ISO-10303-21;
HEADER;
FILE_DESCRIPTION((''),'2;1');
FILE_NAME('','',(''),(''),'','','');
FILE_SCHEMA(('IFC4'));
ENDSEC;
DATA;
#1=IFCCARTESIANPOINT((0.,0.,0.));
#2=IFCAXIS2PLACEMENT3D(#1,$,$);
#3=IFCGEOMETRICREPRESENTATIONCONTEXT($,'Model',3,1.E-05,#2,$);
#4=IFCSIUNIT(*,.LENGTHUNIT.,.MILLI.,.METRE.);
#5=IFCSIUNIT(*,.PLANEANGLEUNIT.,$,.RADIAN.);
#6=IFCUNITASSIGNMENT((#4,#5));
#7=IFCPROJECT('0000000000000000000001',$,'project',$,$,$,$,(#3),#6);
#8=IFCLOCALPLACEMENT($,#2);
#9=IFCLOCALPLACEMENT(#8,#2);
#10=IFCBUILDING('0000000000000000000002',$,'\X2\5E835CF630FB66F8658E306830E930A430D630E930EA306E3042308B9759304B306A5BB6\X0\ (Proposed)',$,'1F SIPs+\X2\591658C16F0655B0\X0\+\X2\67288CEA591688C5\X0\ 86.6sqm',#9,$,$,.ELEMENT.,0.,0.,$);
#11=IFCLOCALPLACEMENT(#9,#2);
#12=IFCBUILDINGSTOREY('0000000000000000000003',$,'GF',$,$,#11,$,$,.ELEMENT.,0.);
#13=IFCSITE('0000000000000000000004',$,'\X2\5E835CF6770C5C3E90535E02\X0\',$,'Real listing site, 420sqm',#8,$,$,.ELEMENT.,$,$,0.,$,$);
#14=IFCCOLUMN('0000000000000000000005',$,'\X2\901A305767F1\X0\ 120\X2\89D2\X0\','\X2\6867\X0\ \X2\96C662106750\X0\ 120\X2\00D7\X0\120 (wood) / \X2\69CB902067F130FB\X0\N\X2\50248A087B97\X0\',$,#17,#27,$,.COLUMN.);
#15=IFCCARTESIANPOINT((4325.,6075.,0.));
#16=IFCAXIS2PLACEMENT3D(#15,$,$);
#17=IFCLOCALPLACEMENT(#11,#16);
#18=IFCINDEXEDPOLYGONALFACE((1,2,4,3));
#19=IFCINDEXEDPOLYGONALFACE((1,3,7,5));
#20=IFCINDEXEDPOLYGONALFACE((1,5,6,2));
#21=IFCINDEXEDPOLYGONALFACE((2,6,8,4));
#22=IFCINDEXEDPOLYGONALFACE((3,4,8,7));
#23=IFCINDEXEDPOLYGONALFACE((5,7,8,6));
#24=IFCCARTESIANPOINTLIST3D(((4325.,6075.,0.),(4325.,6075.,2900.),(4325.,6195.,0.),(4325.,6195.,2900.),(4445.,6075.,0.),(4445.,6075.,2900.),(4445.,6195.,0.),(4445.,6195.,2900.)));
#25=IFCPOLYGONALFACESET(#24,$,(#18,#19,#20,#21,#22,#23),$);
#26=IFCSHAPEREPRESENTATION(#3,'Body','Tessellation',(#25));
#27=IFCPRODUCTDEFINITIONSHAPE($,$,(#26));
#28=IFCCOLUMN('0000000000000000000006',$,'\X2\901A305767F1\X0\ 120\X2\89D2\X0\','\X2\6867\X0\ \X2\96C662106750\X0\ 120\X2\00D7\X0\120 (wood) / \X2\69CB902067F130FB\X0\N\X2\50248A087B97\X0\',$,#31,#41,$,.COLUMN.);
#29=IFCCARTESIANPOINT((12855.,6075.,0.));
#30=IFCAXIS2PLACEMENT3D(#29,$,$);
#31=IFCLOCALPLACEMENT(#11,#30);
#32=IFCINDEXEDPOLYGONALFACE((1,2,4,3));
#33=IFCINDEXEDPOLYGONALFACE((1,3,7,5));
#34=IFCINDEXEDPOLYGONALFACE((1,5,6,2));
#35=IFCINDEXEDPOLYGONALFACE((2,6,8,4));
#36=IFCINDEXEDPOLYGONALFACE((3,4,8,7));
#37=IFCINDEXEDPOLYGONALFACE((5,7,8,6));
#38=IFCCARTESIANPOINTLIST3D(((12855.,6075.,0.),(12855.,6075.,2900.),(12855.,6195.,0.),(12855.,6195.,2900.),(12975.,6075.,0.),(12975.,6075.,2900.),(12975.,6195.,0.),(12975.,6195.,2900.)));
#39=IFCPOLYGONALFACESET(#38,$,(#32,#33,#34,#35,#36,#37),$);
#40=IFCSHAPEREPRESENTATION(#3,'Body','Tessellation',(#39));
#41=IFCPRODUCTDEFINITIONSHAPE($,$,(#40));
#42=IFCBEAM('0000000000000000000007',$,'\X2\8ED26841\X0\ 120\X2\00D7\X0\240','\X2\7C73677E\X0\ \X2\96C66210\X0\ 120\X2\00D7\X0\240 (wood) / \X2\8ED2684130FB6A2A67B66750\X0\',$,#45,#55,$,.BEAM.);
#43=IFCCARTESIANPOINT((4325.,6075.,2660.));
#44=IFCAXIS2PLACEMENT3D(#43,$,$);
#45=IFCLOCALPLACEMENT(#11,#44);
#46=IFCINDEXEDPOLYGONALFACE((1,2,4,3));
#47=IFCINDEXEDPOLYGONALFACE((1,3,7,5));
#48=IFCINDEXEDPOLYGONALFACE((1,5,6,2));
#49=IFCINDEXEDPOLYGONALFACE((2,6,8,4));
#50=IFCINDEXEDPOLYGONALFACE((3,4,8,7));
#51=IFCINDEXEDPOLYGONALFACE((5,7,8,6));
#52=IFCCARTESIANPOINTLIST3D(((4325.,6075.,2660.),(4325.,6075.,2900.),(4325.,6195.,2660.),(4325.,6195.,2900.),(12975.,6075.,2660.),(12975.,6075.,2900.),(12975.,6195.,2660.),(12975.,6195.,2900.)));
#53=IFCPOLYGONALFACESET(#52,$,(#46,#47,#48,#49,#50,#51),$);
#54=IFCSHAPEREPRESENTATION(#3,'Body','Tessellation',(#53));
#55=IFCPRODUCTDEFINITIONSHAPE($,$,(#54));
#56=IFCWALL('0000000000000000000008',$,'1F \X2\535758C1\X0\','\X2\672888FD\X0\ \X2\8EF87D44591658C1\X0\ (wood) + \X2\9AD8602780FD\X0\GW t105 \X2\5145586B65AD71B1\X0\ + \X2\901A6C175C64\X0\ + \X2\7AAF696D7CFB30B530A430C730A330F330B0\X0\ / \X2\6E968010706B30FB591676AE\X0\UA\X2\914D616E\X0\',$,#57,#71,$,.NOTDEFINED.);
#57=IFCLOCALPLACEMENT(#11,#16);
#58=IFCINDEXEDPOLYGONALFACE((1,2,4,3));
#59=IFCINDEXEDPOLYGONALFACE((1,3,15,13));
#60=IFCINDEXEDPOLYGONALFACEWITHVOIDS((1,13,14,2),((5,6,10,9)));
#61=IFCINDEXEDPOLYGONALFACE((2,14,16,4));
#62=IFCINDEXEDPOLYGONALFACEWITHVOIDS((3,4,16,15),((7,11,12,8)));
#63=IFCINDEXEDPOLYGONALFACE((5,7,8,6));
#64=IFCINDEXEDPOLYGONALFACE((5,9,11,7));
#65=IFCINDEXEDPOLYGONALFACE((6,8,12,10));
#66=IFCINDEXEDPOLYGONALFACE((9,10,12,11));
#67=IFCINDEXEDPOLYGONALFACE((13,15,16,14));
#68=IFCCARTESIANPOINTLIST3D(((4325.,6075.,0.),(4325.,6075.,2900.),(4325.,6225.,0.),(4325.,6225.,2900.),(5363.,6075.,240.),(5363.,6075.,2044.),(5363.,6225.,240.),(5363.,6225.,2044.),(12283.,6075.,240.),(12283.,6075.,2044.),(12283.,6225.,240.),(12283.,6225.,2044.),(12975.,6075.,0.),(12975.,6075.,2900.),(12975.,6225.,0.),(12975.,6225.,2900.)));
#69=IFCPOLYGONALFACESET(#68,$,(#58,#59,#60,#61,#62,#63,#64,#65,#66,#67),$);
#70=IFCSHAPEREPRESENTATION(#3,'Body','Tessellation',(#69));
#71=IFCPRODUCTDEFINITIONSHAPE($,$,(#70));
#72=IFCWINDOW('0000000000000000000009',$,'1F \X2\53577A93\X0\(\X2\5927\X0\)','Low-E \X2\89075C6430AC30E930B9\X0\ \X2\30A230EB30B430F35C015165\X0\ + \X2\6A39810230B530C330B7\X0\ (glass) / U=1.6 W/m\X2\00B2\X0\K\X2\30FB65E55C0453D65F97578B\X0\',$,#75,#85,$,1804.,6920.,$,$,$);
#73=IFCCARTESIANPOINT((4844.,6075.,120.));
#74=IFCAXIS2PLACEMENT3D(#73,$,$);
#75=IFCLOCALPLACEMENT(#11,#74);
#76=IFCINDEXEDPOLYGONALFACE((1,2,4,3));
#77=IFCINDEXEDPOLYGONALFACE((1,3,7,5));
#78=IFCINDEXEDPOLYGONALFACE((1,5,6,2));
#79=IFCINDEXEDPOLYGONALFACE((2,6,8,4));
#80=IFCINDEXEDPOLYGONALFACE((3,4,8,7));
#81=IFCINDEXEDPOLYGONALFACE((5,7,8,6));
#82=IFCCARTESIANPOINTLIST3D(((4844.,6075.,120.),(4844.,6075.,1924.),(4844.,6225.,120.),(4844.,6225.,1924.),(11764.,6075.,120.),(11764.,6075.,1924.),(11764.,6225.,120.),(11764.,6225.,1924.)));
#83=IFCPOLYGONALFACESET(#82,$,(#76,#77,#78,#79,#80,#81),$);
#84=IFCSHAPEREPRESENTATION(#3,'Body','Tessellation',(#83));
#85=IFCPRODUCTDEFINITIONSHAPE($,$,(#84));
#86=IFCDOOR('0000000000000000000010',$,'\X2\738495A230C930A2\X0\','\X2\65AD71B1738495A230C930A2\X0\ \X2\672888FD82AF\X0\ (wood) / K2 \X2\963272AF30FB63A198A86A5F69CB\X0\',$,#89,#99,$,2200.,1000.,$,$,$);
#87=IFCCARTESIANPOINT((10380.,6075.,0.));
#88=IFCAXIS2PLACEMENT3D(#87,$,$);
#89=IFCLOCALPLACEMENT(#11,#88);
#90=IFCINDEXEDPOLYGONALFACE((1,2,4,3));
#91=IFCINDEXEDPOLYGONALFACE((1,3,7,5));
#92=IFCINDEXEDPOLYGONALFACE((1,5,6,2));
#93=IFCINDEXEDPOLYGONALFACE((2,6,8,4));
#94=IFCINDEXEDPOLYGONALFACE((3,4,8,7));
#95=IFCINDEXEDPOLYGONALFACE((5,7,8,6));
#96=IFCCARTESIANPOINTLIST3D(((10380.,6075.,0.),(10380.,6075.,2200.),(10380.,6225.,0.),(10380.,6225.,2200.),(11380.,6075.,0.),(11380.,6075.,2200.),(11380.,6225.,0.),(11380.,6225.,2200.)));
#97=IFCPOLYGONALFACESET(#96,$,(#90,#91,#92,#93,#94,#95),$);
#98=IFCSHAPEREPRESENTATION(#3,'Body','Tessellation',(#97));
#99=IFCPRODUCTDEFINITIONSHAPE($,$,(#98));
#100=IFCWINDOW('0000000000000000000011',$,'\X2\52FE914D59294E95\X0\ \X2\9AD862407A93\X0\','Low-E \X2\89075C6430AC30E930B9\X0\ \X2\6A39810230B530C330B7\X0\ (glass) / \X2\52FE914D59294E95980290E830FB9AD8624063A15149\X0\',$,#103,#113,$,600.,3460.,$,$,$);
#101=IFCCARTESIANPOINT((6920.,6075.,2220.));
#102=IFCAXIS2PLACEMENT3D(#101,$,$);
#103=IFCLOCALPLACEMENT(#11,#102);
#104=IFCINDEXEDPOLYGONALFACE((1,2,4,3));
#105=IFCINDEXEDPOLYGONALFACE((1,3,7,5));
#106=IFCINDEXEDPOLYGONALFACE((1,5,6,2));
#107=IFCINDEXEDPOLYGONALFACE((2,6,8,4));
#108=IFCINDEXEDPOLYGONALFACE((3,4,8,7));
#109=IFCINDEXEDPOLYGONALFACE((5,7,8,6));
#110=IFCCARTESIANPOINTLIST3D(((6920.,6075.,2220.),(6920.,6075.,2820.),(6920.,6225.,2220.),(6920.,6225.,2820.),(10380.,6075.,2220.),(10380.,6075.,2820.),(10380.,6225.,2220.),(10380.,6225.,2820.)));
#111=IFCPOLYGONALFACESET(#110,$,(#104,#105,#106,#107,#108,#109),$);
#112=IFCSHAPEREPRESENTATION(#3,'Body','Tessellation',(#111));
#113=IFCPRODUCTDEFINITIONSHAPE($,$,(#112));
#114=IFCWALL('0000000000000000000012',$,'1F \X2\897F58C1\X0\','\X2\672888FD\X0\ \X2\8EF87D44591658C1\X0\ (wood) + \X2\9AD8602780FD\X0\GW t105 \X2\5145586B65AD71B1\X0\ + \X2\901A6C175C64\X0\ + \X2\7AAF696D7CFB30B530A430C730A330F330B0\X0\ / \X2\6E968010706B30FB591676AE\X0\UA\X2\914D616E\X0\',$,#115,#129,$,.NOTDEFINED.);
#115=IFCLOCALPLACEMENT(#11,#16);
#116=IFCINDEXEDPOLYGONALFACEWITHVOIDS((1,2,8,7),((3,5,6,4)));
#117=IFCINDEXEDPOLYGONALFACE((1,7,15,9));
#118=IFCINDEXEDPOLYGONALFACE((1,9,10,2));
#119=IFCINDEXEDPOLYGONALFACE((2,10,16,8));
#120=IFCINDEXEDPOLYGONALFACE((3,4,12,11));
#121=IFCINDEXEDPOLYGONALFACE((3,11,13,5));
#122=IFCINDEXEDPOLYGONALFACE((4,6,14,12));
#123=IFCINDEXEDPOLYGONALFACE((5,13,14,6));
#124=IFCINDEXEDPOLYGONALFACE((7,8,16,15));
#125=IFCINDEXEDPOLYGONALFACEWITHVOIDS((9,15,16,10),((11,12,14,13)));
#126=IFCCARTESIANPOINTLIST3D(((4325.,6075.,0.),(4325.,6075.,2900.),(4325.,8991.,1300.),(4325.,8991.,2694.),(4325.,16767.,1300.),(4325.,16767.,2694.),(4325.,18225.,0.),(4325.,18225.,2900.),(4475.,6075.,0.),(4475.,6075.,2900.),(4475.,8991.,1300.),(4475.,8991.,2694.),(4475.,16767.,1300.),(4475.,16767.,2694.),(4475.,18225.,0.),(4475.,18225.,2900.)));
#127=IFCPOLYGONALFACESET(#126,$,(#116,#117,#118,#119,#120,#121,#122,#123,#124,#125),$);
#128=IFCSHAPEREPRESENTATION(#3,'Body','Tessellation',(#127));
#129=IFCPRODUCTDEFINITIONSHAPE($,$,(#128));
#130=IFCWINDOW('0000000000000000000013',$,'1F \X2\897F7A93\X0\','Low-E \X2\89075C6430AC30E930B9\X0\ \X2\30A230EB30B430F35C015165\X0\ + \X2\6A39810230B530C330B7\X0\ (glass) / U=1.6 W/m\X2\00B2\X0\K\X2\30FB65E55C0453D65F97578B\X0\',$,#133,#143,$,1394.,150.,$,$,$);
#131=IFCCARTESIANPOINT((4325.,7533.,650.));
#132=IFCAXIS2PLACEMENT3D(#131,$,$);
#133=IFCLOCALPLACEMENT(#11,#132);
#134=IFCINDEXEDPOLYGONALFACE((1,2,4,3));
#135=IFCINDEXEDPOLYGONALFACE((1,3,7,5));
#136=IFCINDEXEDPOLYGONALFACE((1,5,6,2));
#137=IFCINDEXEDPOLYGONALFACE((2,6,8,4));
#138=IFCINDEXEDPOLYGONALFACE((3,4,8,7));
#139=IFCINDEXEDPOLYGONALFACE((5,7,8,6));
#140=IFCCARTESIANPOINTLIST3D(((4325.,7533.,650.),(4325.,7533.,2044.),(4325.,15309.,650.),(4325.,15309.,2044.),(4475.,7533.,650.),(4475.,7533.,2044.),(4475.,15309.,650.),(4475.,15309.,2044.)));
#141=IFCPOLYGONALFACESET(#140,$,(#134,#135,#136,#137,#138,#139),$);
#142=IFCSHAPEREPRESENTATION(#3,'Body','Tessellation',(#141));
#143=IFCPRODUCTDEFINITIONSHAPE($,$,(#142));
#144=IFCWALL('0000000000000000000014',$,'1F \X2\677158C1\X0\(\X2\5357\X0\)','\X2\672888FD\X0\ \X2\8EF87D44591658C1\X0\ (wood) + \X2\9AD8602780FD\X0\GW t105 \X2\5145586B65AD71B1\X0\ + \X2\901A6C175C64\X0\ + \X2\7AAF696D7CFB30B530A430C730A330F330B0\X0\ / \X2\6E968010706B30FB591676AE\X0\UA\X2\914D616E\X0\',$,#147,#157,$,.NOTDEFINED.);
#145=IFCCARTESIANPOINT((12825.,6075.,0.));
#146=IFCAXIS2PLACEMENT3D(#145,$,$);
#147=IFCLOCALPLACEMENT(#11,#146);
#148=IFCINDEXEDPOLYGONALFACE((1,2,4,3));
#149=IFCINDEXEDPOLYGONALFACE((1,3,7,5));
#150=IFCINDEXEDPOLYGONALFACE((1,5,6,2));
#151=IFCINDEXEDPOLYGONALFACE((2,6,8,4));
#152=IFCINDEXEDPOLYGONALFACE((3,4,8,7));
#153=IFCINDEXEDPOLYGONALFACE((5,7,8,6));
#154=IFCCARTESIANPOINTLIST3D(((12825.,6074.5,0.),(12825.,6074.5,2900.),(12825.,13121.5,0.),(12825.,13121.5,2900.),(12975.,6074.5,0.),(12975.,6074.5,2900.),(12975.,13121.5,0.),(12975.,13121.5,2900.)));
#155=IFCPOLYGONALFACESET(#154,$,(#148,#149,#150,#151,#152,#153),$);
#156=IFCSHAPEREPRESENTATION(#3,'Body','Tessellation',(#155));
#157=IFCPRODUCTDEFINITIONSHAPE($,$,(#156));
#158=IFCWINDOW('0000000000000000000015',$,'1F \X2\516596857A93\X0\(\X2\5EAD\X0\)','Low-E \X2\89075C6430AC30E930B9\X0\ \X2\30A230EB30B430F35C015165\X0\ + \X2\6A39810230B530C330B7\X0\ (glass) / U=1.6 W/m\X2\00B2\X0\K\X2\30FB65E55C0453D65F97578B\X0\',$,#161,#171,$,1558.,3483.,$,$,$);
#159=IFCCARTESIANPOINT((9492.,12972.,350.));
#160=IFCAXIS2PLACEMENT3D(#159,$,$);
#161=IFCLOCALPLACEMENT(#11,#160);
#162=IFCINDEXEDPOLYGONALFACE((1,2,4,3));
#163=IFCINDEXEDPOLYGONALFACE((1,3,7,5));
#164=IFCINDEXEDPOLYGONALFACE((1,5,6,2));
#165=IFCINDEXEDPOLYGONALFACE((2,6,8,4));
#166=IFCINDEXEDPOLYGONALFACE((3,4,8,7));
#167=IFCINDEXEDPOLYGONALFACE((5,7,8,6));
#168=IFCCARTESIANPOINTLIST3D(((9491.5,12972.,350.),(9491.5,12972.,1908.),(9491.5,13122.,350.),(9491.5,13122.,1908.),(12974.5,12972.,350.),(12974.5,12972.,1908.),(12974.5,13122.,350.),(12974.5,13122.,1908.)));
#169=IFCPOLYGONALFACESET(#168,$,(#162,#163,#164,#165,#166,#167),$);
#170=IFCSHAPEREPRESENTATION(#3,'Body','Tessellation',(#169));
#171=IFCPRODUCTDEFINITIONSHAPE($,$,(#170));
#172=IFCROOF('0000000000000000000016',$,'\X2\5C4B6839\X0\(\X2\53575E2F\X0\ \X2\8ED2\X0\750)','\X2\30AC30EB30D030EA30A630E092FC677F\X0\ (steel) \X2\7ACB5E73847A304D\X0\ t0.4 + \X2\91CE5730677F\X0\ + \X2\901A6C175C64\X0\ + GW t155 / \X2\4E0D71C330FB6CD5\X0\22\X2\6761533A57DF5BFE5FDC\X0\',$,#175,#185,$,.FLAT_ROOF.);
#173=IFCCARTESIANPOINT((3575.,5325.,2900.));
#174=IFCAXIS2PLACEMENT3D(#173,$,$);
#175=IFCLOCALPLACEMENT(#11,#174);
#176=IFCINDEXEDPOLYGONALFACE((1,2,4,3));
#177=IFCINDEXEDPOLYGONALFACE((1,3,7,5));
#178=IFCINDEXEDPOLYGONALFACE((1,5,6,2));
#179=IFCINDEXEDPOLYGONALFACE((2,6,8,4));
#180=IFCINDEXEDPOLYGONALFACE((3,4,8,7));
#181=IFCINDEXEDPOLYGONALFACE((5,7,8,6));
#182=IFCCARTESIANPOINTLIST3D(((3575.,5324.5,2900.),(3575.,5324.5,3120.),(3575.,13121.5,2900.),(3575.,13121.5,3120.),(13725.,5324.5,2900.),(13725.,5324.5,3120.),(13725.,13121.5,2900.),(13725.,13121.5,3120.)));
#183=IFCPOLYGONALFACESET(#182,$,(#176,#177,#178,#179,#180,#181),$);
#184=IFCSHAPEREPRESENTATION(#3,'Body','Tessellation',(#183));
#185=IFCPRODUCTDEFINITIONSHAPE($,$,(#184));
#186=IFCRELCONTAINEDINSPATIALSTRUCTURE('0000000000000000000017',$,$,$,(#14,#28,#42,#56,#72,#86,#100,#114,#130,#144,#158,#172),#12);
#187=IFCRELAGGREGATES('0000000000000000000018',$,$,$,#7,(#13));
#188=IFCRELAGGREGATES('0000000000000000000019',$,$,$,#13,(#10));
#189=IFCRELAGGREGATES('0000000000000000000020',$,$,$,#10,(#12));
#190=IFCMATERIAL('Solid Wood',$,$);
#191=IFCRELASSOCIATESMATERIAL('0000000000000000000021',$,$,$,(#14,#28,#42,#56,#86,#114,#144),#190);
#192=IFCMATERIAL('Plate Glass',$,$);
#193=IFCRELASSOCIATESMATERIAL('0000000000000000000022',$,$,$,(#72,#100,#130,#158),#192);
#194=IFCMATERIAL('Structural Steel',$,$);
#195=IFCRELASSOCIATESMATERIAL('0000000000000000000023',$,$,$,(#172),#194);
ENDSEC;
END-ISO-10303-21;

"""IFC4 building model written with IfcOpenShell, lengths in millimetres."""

from ifc_helpers import new_model, si_unit, frame, frame_2d, origin, place, context, project, spatial, rectangle, extrude, material, element, fill, save


model = new_model("IFC4")

# Units and contexts
model_context = context("Model", 3, precision=1e-05, world=origin())
ifc_project = project(units=[si_unit("LENGTHUNIT", "METRE", prefix="MILLI"), si_unit("PLANEANGLEUNIT", "RADIAN")], contexts=[model_context])

# Site, building, storey
site_placement = place(None, origin())
site = spatial("IfcSite", under=ifc_project, at=site_placement, Name="広島県尾道市", ObjectType="Real listing site, 420sqm", CompositionType="ELEMENT", RefElevation=0.0)
building_placement = place(site_placement, origin())
building = spatial("IfcBuilding", under=site, at=building_placement, Name="広島・書斎とライブラリのある静かな家 (Proposed)", ObjectType="1F SIPs+外壁漆喰+木質外装 86.6sqm", CompositionType="ELEMENT", ElevationOfRefHeight=0.0, ElevationOfTerrain=0.0)
storey_placement = place(building_placement, origin())
storey = spatial("IfcBuildingStorey", under=building, at=storey_placement, Name="GF", CompositionType="ELEMENT", Elevation=0.0)

# Columns
ifc_material_1 = material(Name="Solid Wood")
column_1_placement = place(storey_placement, frame((4325.0, 6075.0, 0.0)))
element("IfcColumn", 1, at=column_1_placement, inside=storey, material=ifc_material_1, Name="通し柱 120角", Description="桧 集成材 120×120 (wood) / 構造柱・N値計算", PredefinedType="COLUMN", context=model_context, shape_type="SweptSolid", body=[
    extrude(rectangle(XDim=120.0, YDim=120.0, at=frame_2d((60.0, 60.0))), frame((4325.0, 6075.0, 0.0)), (0.0, 0.0, 1.0), 2900.0),
])
column_2_placement = place(storey_placement, frame((12855.0, 6075.0, 0.0)))
element("IfcColumn", 2, at=column_2_placement, inside=storey, material=ifc_material_1, Name="通し柱 120角", Description="桧 集成材 120×120 (wood) / 構造柱・N値計算", PredefinedType="COLUMN", context=model_context, shape_type="SweptSolid", body=[
    extrude(rectangle(XDim=120.0, YDim=120.0, at=frame_2d((60.0, 60.0))), frame((12855.0, 6075.0, 0.0)), (0.0, 0.0, 1.0), 2900.0),
])

# Beam
beam_1_placement = place(storey_placement, frame((4325.0, 6075.0, 2660.0)))
element("IfcBeam", 3, at=beam_1_placement, inside=storey, material=ifc_material_1, Name="軒桁 120×240", Description="米松 集成 120×240 (wood) / 軒桁・横架材", PredefinedType="BEAM", context=model_context, shape_type="SweptSolid", body=[
    extrude(rectangle(XDim=8650.0, YDim=120.0, at=frame_2d((4325.0, 60.0))), frame((4325.0, 6075.0, 2660.0)), (0.0, 0.0, 1.0), 240.0),
])

# Wall, openings, windows, door
wall_1_placement = place(storey_placement, frame((4325.0, 6075.0, 0.0)))
wall_1 = element("IfcWall", 4, at=wall_1_placement, inside=storey, material=ifc_material_1, Name="1F 南壁", Description="木製 軸組外壁 (wood) + 高性能GW t105 充填断熱 + 通気層 + 窯業系サイディング / 準耐火・外皮UA配慮", PredefinedType="NOTDEFINED", context=model_context, shape_type="SweptSolid", body=[
    extrude(rectangle(XDim=8650.0, YDim=150.0, at=frame_2d((4325.0, 75.0))), frame((4325.0, 6075.0, 0.0)), (0.0, 0.0, 1.0), 2900.0),
])
opening_1_placement = place(storey_placement, frame((4844.0, 6075.0, 120.0)))
opening_1 = element("IfcOpeningElement", 5, at=opening_1_placement, cuts=wall_1, PredefinedType="NOTDEFINED", context=model_context, shape_type="SweptSolid", body=[
    extrude(rectangle(XDim=6920.0, YDim=150.0, at=frame_2d((3460.0, 75.0))), frame((4844.0, 6075.0, 120.0)), (0.0, 0.0, 1.0), 1804.0),
])
opening_2_placement = place(storey_placement, frame((10380.0, 6075.0, 0.0)))
opening_2 = element("IfcOpeningElement", 6, at=opening_2_placement, cuts=wall_1, PredefinedType="NOTDEFINED", context=model_context, shape_type="SweptSolid", body=[
    extrude(rectangle(XDim=1000.0, YDim=150.0, at=frame_2d((500.0, 75.0))), frame((10380.0, 6075.0, 0.0)), (0.0, 0.0, 1.0), 2200.0),
])
opening_3_placement = place(storey_placement, frame((6920.0, 6075.0, 2220.0)))
opening_3 = element("IfcOpeningElement", 7, at=opening_3_placement, cuts=wall_1, PredefinedType="NOTDEFINED", context=model_context, shape_type="SweptSolid", body=[
    extrude(rectangle(XDim=3460.0, YDim=150.0, at=frame_2d((1730.0, 75.0))), frame((6920.0, 6075.0, 2220.0)), (0.0, 0.0, 1.0), 600.0),
])
ifc_material_2 = material(Name="Plate Glass")
window_1_placement = place(storey_placement, frame((4844.0, 6075.0, 120.0)))
window_1 = element("IfcWindow", 8, at=window_1_placement, inside=storey, material=ifc_material_2, Name="1F 南窓(大)", Description="Low-E 複層ガラス アルゴン封入 + 樹脂サッシ (glass) / U=1.6 W/m²K・日射取得型", OverallHeight=1804.0, OverallWidth=6920.0, context=model_context, shape_type="SweptSolid", body=[
    extrude(rectangle(XDim=6920.0, YDim=150.0, at=frame_2d((3460.0, 75.0))), frame((4844.0, 6075.0, 120.0)), (0.0, 0.0, 1.0), 1804.0),
])
fill(opening_1, window_1)
door_1_placement = place(storey_placement, frame((10380.0, 6075.0, 0.0)))
door_1 = element("IfcDoor", 9, at=door_1_placement, inside=storey, material=ifc_material_1, Name="玄関ドア", Description="断熱玄関ドア 木製芯 (wood) / K2 防犯・採風機構", OverallHeight=2200.0, OverallWidth=1000.0, context=model_context, shape_type="SweptSolid", body=[
    extrude(rectangle(XDim=1000.0, YDim=150.0, at=frame_2d((500.0, 75.0))), frame((10380.0, 6075.0, 0.0)), (0.0, 0.0, 1.0), 2200.0),
])
fill(opening_2, door_1)
window_2_placement = place(storey_placement, frame((6920.0, 6075.0, 2220.0)))
window_2 = element("IfcWindow", 10, at=window_2_placement, inside=storey, material=ifc_material_2, Name="勾配天井 高所窓", Description="Low-E 複層ガラス 樹脂サッシ (glass) / 勾配天井頂部・高所採光", OverallHeight=600.0, OverallWidth=3460.0, context=model_context, shape_type="SweptSolid", body=[
    extrude(rectangle(XDim=3460.0, YDim=150.0, at=frame_2d((1730.0, 75.0))), frame((6920.0, 6075.0, 2220.0)), (0.0, 0.0, 1.0), 600.0),
])
fill(opening_3, window_2)

# Walls, openings, windows
wall_2_placement = place(storey_placement, frame((4325.0, 6075.0, 0.0)))
wall_2 = element("IfcWall", 11, at=wall_2_placement, inside=storey, material=ifc_material_1, Name="1F 西壁", Description="木製 軸組外壁 (wood) + 高性能GW t105 充填断熱 + 通気層 + 窯業系サイディング / 準耐火・外皮UA配慮", PredefinedType="NOTDEFINED", context=model_context, shape_type="SweptSolid", body=[
    extrude(rectangle(XDim=150.0, YDim=12150.0, at=frame_2d((75.0, 6075.0))), frame((4325.0, 6075.0, 0.0)), (0.0, 0.0, 1.0), 2900.0),
])
opening_4_placement = place(storey_placement, frame((4325.0, 7533.0, 650.0)))
opening_4 = element("IfcOpeningElement", 12, at=opening_4_placement, cuts=wall_2, PredefinedType="NOTDEFINED", context=model_context, shape_type="SweptSolid", body=[
    extrude(rectangle(XDim=150.0, YDim=7776.0, at=frame_2d((75.0, 3888.0))), frame((4325.0, 7533.0, 650.0)), (0.0, 0.0, 1.0), 1394.0),
])
window_3_placement = place(storey_placement, frame((4325.0, 7533.0, 650.0)))
window_3 = element("IfcWindow", 13, at=window_3_placement, inside=storey, material=ifc_material_2, Name="1F 西窓", Description="Low-E 複層ガラス アルゴン封入 + 樹脂サッシ (glass) / U=1.6 W/m²K・日射取得型", OverallHeight=1394.0, OverallWidth=150.0, context=model_context, shape_type="SweptSolid", body=[
    extrude(rectangle(XDim=150.0, YDim=7776.0, at=frame_2d((75.0, 3888.0))), frame((4325.0, 7533.0, 650.0)), (0.0, 0.0, 1.0), 1394.0),
])
fill(opening_4, window_3)
wall_3_placement = place(storey_placement, frame((12825.0, 6075.0, 0.0)))
wall_3 = element("IfcWall", 14, at=wall_3_placement, inside=storey, material=ifc_material_1, Name="1F 東壁(南)", Description="木製 軸組外壁 (wood) + 高性能GW t105 充填断熱 + 通気層 + 窯業系サイディング / 準耐火・外皮UA配慮", PredefinedType="NOTDEFINED", context=model_context, shape_type="SweptSolid", body=[
    extrude(rectangle(XDim=150.0, YDim=7047.0, at=frame_2d((75.0, 3523.0))), frame((12825.0, 6075.0, 0.0)), (0.0, 0.0, 1.0), 2900.0),
])
opening_5_placement = place(storey_placement, frame((9492.0, 12972.0, 350.0)))
opening_5 = element("IfcOpeningElement", 15, at=opening_5_placement, cuts=wall_3, PredefinedType="NOTDEFINED", context=model_context, shape_type="SweptSolid", body=[
    extrude(rectangle(XDim=3483.0, YDim=150.0, at=frame_2d((1741.0, 75.0))), frame((9492.0, 12972.0, 350.0)), (0.0, 0.0, 1.0), 1558.0),
])
window_4_placement = place(storey_placement, frame((9492.0, 12972.0, 350.0)))
window_4 = element("IfcWindow", 16, at=window_4_placement, inside=storey, material=ifc_material_2, Name="1F 入隅窓(庭)", Description="Low-E 複層ガラス アルゴン封入 + 樹脂サッシ (glass) / U=1.6 W/m²K・日射取得型", OverallHeight=1558.0, OverallWidth=3483.0, context=model_context, shape_type="SweptSolid", body=[
    extrude(rectangle(XDim=3483.0, YDim=150.0, at=frame_2d((1741.0, 75.0))), frame((9492.0, 12972.0, 350.0)), (0.0, 0.0, 1.0), 1558.0),
])
fill(opening_5, window_4)

# Roof
ifc_material_3 = material(Name="Structural Steel")
roof_placement = place(storey_placement, frame((3575.0, 5325.0, 2900.0)))
element("IfcRoof", 17, at=roof_placement, inside=storey, material=ifc_material_3, Name="屋根(南帯 軒750)", Description="ガルバリウム鋼板 (steel) 立平葺き t0.4 + 野地板 + 通気層 + GW t155 / 不燃・法22条区域対応", PredefinedType="FLAT_ROOF", context=model_context, shape_type="SweptSolid", body=[
    extrude(rectangle(XDim=10150.0, YDim=7797.0, at=frame_2d((5075.0, 3898.0))), frame((3575.0, 5325.0, 2900.0)), (0.0, 0.0, 1.0), 220.0),
])

save(model, "model.ifc")
